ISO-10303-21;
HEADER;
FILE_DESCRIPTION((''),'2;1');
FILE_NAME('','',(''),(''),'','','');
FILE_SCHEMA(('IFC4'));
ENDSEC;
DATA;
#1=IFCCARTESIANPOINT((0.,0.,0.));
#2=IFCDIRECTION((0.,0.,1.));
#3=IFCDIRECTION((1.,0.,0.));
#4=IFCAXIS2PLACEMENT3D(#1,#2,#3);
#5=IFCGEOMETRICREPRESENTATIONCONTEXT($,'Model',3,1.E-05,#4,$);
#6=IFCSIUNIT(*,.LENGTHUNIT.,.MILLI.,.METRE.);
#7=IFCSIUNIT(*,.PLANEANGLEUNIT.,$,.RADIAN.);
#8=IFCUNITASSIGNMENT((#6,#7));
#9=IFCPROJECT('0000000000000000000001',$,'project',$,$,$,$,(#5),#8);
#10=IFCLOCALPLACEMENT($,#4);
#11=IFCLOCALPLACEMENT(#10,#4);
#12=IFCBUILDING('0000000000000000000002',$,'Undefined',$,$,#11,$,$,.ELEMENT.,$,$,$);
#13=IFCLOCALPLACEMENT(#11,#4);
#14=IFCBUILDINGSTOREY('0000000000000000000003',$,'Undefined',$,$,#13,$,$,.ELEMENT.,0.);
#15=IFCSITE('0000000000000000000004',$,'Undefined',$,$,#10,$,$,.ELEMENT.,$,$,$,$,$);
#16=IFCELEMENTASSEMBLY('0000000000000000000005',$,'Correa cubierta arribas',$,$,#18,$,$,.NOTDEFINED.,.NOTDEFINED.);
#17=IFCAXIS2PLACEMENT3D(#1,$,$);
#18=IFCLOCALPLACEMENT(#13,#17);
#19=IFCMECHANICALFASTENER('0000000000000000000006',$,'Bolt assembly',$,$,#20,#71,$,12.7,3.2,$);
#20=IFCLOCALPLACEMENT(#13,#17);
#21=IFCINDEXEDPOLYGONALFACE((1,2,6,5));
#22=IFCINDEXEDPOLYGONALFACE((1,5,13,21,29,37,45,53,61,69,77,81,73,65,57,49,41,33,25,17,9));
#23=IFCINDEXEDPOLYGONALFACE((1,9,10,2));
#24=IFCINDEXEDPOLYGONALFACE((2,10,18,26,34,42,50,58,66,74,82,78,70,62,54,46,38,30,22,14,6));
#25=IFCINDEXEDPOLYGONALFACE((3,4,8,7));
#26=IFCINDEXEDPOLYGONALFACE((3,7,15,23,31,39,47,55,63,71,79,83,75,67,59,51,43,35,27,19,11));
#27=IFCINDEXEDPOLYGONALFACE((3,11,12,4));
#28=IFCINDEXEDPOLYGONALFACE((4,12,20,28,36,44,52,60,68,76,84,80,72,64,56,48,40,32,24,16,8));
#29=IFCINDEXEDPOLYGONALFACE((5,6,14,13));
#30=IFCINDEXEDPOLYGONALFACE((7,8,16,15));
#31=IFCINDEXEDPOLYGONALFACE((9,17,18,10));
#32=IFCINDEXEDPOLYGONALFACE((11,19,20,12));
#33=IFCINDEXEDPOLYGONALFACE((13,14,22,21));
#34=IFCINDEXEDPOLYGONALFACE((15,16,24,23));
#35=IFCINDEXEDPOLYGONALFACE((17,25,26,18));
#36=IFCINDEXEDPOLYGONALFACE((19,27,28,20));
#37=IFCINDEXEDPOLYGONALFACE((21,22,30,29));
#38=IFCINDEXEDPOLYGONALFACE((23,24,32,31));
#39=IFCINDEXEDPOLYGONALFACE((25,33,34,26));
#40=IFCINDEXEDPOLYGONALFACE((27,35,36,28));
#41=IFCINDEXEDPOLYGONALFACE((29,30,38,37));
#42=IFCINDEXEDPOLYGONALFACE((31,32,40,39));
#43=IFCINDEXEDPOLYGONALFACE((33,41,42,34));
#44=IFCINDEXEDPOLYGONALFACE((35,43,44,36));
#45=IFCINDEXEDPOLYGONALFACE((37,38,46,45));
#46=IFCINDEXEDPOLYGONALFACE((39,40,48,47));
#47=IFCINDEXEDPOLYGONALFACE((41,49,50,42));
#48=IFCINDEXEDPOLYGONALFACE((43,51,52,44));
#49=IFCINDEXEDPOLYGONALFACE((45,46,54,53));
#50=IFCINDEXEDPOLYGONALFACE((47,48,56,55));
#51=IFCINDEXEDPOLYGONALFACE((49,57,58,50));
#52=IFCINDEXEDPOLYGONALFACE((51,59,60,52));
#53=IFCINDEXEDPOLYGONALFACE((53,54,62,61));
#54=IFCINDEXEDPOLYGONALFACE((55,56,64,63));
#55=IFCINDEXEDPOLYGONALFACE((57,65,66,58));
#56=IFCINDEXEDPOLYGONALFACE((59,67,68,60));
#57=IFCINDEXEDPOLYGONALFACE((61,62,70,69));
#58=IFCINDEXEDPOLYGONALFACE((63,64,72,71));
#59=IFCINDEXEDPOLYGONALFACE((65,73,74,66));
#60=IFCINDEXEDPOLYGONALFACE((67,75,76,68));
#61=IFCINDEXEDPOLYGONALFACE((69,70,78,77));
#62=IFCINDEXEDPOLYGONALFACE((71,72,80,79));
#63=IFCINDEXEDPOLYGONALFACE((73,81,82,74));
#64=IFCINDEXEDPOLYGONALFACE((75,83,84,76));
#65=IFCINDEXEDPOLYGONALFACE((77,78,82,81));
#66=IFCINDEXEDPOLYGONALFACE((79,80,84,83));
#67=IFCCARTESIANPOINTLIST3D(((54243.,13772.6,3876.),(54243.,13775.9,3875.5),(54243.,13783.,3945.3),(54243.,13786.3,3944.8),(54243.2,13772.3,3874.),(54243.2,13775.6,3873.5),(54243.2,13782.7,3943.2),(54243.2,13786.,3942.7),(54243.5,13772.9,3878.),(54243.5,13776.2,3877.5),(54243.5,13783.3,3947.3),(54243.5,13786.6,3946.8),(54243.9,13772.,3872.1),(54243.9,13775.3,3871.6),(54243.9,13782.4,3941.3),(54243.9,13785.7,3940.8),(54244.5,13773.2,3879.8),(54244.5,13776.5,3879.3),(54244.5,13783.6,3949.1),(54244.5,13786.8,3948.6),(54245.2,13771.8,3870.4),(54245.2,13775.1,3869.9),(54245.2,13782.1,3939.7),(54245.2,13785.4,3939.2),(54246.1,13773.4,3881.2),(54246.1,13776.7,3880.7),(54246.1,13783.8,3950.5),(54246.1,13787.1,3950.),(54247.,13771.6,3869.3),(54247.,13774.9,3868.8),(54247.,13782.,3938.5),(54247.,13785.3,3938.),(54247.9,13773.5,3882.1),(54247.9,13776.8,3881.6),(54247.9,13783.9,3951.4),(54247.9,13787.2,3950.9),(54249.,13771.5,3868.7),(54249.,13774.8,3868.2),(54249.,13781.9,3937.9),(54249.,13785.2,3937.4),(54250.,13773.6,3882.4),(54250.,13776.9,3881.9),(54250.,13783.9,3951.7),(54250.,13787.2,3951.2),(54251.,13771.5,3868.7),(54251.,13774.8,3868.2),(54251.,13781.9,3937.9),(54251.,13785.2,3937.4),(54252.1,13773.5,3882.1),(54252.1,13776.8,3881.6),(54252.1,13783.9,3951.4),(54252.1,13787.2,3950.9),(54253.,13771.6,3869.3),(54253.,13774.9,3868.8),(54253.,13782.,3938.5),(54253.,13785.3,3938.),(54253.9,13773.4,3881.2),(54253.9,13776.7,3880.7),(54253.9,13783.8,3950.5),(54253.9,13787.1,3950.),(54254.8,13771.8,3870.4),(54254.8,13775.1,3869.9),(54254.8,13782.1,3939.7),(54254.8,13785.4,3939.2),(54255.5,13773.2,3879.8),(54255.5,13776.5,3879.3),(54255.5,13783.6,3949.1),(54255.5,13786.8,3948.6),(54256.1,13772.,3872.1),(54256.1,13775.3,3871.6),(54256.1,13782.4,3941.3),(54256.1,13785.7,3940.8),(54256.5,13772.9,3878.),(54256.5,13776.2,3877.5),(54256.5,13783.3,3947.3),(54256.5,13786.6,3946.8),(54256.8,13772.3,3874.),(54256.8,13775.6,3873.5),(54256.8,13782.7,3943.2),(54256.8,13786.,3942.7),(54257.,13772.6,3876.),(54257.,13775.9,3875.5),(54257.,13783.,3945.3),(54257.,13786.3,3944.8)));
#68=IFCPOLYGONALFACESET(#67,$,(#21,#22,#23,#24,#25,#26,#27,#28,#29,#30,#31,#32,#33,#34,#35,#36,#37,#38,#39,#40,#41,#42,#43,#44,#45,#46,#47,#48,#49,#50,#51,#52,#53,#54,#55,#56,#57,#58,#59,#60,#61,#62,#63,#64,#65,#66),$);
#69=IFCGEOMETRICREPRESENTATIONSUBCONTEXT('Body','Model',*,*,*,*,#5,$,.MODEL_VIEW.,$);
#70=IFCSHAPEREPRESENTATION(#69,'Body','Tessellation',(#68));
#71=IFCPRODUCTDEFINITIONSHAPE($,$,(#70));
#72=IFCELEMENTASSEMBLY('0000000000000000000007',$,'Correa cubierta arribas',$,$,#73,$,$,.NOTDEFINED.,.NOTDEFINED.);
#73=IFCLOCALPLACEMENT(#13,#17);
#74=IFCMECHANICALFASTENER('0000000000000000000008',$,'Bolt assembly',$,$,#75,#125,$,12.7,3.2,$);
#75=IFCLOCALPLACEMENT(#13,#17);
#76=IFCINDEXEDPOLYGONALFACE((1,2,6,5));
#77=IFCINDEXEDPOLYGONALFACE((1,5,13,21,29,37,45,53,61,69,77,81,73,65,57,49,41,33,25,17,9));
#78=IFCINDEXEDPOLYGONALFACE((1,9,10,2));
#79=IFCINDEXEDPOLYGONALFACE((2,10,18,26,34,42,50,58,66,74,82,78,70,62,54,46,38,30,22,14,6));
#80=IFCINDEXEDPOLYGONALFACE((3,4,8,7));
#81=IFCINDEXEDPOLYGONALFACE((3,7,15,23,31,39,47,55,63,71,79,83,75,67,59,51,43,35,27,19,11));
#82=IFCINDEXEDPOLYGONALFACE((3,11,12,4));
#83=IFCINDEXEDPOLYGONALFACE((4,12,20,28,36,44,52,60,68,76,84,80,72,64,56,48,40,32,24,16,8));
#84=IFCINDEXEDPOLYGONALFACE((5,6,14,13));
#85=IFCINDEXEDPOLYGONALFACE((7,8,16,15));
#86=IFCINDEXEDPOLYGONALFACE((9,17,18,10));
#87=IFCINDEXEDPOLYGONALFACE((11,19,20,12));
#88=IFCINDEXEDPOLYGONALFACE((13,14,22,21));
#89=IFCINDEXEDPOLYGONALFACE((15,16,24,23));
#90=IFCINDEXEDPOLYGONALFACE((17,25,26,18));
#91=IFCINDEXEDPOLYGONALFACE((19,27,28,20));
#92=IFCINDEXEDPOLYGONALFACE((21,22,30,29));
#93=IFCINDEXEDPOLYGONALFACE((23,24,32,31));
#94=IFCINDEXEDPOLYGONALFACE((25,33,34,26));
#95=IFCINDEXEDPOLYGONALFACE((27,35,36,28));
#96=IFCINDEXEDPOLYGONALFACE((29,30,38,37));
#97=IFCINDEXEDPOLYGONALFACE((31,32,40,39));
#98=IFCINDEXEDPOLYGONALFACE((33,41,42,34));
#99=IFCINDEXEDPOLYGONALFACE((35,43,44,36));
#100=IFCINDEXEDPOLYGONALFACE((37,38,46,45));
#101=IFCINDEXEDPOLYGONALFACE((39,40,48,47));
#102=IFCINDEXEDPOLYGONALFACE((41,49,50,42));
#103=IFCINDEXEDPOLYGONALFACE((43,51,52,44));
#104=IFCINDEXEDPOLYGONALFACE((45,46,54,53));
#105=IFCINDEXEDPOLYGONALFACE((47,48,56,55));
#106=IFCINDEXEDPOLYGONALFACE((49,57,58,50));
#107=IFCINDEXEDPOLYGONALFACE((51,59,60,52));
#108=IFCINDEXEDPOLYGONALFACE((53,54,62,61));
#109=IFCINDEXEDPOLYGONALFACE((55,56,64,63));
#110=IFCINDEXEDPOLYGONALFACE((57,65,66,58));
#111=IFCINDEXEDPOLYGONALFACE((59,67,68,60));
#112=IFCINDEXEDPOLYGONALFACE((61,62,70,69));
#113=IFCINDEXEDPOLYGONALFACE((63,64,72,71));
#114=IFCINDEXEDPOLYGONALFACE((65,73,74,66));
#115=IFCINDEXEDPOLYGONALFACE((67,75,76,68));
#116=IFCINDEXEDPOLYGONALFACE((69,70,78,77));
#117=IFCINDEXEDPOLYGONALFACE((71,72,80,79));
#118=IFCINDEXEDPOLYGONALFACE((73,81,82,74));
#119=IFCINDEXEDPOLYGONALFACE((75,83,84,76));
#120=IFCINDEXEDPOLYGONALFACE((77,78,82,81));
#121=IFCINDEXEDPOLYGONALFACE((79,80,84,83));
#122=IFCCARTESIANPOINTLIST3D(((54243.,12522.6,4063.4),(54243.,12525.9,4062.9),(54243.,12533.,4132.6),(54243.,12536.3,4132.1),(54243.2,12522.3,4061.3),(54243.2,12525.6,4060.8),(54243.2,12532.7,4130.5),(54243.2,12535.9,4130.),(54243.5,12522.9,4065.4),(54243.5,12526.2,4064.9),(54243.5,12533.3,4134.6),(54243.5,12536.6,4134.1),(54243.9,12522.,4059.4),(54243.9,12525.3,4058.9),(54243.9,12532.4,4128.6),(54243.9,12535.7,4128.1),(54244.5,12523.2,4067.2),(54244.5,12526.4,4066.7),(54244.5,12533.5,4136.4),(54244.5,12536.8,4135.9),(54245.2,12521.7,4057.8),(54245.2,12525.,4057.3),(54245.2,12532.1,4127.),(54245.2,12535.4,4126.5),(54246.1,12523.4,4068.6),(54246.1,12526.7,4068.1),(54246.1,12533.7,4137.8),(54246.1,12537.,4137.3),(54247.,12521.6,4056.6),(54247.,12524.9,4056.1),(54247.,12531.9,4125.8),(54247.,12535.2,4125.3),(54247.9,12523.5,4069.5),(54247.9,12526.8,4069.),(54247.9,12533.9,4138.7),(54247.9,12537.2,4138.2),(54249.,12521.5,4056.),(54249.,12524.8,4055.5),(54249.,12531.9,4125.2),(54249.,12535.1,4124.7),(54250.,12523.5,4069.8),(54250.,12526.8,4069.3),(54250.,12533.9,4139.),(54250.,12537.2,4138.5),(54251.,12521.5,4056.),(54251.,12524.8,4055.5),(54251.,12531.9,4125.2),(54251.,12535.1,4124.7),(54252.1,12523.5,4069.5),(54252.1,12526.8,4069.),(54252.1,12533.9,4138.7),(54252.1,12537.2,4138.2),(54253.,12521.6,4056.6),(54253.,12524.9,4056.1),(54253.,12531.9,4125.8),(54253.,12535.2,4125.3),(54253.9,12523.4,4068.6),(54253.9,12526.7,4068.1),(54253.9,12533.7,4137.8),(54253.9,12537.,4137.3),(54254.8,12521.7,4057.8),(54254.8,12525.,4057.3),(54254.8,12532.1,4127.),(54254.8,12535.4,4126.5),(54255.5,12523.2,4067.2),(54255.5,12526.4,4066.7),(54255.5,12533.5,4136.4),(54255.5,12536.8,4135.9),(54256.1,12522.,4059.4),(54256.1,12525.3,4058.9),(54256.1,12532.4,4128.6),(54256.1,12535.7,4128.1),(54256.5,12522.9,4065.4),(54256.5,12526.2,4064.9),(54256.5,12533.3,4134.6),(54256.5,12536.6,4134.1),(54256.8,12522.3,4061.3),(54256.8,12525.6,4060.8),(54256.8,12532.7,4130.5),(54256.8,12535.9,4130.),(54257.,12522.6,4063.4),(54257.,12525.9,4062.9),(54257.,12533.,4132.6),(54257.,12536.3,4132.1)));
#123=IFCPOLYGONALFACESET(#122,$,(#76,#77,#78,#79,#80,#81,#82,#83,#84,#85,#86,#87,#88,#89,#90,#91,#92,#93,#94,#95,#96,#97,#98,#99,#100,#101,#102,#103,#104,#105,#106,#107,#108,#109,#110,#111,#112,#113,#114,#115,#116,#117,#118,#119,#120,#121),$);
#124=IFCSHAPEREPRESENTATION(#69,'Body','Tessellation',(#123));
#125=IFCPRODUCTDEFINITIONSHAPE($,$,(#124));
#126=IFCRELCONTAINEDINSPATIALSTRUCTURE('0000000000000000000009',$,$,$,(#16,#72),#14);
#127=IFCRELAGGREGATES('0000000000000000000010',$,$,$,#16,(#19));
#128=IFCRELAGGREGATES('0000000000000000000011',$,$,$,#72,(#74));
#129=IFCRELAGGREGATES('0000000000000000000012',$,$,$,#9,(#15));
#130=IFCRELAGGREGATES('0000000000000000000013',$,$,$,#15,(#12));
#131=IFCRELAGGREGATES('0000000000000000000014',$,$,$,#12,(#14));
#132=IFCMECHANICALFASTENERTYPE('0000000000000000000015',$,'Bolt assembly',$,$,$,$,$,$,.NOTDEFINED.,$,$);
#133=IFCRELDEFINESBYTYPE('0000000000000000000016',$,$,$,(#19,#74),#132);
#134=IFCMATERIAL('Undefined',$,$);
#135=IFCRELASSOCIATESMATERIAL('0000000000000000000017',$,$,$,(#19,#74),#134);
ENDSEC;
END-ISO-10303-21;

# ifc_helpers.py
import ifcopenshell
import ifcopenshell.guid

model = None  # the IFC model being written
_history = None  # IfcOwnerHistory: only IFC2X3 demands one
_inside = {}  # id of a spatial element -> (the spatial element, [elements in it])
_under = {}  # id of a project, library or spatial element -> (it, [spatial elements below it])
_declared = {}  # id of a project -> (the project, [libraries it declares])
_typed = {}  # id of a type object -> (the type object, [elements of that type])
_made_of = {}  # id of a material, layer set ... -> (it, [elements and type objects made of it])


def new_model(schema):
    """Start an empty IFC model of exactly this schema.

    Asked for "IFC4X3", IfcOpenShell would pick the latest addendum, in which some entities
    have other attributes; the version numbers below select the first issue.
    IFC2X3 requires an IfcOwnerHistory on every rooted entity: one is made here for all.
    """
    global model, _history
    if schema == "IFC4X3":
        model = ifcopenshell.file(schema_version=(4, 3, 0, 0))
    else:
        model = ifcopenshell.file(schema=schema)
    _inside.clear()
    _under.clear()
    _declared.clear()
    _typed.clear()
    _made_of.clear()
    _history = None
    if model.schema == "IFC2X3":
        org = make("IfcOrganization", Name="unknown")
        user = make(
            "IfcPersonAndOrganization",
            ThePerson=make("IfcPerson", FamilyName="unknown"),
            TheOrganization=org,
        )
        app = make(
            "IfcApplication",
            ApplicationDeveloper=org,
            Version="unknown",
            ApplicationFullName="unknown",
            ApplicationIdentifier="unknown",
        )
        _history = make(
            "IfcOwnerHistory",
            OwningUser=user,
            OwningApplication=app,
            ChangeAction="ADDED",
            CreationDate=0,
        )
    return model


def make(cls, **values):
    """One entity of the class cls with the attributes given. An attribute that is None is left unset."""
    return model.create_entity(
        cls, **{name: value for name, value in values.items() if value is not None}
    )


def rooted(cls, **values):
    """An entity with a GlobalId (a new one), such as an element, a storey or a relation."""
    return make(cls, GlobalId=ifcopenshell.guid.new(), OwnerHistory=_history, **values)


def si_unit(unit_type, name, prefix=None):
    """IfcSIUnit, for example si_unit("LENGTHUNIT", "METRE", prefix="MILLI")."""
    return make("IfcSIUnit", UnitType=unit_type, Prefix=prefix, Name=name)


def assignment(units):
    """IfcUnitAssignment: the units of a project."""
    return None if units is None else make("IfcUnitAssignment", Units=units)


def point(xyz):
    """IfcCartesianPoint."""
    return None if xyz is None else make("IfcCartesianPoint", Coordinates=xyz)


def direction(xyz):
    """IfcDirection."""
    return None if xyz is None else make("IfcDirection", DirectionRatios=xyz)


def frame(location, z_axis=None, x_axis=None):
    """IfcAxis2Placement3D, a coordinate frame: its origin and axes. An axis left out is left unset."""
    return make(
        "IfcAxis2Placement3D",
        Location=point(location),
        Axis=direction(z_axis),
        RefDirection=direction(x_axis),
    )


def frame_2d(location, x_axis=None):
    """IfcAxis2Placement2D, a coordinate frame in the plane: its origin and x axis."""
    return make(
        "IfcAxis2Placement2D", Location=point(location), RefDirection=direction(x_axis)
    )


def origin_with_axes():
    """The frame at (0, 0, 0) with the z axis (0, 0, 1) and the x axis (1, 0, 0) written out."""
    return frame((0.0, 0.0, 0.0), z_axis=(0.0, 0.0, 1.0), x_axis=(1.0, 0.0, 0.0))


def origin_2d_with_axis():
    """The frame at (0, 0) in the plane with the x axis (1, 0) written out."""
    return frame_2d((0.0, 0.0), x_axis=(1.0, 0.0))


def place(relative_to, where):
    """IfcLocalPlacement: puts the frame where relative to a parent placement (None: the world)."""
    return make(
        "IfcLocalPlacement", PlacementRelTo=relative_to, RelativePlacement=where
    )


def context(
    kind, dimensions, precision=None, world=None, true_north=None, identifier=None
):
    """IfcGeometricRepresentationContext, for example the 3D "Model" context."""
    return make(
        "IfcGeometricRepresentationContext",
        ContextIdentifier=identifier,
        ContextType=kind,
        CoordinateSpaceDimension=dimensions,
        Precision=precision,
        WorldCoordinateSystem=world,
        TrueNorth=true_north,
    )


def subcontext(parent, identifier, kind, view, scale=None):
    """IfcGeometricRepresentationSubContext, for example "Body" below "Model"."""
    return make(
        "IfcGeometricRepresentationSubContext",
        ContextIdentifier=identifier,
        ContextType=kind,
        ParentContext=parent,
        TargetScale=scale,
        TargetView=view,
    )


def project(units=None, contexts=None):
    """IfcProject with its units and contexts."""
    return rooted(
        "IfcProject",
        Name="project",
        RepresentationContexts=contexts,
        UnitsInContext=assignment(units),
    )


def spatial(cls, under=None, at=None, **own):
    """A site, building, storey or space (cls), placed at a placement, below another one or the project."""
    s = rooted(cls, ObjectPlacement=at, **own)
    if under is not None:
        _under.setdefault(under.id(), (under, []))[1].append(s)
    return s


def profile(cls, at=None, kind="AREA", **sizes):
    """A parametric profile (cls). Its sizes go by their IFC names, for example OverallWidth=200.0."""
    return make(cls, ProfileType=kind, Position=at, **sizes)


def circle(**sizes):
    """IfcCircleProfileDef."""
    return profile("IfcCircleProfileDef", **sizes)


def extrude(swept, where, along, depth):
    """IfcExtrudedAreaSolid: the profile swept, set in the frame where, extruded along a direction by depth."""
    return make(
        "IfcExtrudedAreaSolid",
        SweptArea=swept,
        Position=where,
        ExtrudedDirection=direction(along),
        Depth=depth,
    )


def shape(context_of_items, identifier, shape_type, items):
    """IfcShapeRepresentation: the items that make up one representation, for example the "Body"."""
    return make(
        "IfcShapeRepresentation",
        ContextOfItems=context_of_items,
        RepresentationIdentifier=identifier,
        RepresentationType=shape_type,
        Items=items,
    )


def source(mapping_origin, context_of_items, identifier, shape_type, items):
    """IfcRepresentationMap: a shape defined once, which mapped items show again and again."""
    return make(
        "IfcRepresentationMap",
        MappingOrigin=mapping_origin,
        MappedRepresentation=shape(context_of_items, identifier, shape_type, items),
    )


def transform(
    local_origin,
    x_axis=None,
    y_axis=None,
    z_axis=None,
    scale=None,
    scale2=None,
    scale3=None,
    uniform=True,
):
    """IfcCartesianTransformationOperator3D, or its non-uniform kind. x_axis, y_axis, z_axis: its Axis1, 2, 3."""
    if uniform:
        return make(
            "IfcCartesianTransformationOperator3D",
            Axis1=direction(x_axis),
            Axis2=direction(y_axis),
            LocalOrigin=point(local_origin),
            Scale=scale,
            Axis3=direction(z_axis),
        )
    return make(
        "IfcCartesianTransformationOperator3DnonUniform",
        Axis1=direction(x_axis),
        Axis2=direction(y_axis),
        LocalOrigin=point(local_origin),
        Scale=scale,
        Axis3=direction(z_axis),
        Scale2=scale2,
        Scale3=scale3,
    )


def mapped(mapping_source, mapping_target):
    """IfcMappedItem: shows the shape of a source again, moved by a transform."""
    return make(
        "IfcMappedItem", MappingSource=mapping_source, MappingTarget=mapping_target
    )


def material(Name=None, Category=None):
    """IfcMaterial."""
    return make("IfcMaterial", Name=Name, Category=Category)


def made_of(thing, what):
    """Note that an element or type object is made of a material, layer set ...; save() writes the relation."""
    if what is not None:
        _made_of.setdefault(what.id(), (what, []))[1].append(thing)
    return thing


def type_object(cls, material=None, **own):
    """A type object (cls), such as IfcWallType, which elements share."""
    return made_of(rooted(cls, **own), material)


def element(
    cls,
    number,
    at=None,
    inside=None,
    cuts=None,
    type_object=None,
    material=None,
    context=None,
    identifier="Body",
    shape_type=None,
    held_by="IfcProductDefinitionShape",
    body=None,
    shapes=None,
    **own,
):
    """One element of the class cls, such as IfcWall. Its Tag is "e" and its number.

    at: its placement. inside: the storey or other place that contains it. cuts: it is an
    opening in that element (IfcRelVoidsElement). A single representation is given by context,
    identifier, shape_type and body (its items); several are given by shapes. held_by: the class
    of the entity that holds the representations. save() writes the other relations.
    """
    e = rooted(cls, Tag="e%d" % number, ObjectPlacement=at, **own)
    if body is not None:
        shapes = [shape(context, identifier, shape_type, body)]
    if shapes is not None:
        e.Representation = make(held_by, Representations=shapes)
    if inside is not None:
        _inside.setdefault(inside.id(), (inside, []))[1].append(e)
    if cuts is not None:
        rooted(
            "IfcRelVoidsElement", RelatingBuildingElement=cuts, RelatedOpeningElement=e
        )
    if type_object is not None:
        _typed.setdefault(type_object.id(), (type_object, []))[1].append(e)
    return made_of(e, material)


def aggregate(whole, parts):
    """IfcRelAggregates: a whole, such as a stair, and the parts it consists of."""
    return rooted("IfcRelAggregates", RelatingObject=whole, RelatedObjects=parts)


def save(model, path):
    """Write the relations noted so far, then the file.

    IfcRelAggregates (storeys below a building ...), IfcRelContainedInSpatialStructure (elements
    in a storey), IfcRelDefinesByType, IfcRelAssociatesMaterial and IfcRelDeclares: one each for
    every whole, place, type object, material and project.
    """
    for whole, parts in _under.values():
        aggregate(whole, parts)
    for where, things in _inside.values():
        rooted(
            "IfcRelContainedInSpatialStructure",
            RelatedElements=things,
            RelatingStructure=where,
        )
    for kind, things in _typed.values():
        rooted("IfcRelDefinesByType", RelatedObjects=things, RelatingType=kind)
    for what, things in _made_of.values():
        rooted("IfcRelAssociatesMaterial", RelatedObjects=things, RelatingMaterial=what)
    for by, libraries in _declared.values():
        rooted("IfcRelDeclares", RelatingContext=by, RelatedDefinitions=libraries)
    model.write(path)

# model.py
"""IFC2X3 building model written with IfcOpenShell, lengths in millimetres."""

from ifc_helpers import new_model, si_unit, frame, origin_with_axes, origin_2d_with_axis, place, context, subcontext, project, spatial, circle, extrude, source, transform, mapped, material, type_object, element, aggregate, save


model = new_model("IFC2X3")

# Units and contexts
model_context = context("Model", 3, precision=1e-05, world=origin_with_axes())
body_context = subcontext(model_context, "Body", "Model", "MODEL_VIEW")
ifc_project = project(units=[si_unit("LENGTHUNIT", "METRE", prefix="MILLI"), si_unit("PLANEANGLEUNIT", "RADIAN")], contexts=[model_context])

# Site, building, storey
site_placement = place(None, origin_with_axes())
site = spatial("IfcSite", under=ifc_project, at=site_placement, Name="Undefined", CompositionType="ELEMENT")
building_placement = place(site_placement, origin_with_axes())
building = spatial("IfcBuilding", under=site, at=building_placement, Name="Undefined", CompositionType="ELEMENT")
storey_placement = place(building_placement, origin_with_axes())
storey = spatial("IfcBuildingStorey", under=building, at=storey_placement, Name="Undefined", CompositionType="ELEMENT", Elevation=0.0)

# Element assemblies, mechanical fasteners
ifc_material_1 = material(Name="Undefined")
mechanical_fastener_type = type_object("IfcMechanicalFastenerType", Name="Bolt assembly")
shared_shape_1 = source(origin_with_axes(), body_context, "Body", "SweptSolid", [
    extrude(circle(Radius=7.0, at=origin_2d_with_axis()), frame((0.0, 6.4, 0.0), z_axis=(0.0, 1.0, 0.0), x_axis=(1.0, 0.0, 0.0)), (0.0, 0.0, 1.0), 3.3),
])
assembly_1_placement = place(storey_placement, origin_with_axes())
assembly_1 = element("IfcElementAssembly", 1, at=assembly_1_placement, inside=storey, Name="Correa cubierta arribas", AssemblyPlace="NOTDEFINED", PredefinedType="NOTDEFINED")
mechanical_fastener_1_placement = place(assembly_1_placement, frame((54250.0, 13766.2, 3876.5), z_axis=(-1.0, 0.0, 0.0), x_axis=(0.0, 0.148209, 0.988956)))
mechanical_fastener_1 = element("IfcMechanicalFastener", 2, at=mechanical_fastener_1_placement, type_object=mechanical_fastener_type, material=ifc_material_1, Name="Bolt assembly", NominalDiameter=12.7, NominalLength=3.2, context=body_context, shape_type="MappedRepresentation", body=[
    mapped(shared_shape_1, transform((0.0, 0.0, 0.0))),
    mapped(shared_shape_1, transform((70.0, 0.0, 0.0))),
])
aggregate(assembly_1, [mechanical_fastener_1])
assembly_2_placement = place(storey_placement, origin_with_axes())
assembly_2 = element("IfcElementAssembly", 3, at=assembly_2_placement, inside=storey, Name="Correa cubierta arribas", AssemblyPlace="NOTDEFINED", PredefinedType="NOTDEFINED")
mechanical_fastener_2_placement = place(assembly_2_placement, frame((54250.0, 12516.2, 4063.8), z_axis=(-1.0, 0.0, 0.0), x_axis=(0.0, 0.148209, 0.988956)))
mechanical_fastener_2 = element("IfcMechanicalFastener", 4, at=mechanical_fastener_2_placement, type_object=mechanical_fastener_type, material=ifc_material_1, Name="Bolt assembly", NominalDiameter=12.7, NominalLength=3.2, context=body_context, shape_type="MappedRepresentation", body=[
    mapped(shared_shape_1, transform((0.0, 0.0, 0.0))),
    mapped(shared_shape_1, transform((70.0, 0.0, 0.0))),
])
aggregate(assembly_2, [mechanical_fastener_2])

save(model, "model.ifc")
